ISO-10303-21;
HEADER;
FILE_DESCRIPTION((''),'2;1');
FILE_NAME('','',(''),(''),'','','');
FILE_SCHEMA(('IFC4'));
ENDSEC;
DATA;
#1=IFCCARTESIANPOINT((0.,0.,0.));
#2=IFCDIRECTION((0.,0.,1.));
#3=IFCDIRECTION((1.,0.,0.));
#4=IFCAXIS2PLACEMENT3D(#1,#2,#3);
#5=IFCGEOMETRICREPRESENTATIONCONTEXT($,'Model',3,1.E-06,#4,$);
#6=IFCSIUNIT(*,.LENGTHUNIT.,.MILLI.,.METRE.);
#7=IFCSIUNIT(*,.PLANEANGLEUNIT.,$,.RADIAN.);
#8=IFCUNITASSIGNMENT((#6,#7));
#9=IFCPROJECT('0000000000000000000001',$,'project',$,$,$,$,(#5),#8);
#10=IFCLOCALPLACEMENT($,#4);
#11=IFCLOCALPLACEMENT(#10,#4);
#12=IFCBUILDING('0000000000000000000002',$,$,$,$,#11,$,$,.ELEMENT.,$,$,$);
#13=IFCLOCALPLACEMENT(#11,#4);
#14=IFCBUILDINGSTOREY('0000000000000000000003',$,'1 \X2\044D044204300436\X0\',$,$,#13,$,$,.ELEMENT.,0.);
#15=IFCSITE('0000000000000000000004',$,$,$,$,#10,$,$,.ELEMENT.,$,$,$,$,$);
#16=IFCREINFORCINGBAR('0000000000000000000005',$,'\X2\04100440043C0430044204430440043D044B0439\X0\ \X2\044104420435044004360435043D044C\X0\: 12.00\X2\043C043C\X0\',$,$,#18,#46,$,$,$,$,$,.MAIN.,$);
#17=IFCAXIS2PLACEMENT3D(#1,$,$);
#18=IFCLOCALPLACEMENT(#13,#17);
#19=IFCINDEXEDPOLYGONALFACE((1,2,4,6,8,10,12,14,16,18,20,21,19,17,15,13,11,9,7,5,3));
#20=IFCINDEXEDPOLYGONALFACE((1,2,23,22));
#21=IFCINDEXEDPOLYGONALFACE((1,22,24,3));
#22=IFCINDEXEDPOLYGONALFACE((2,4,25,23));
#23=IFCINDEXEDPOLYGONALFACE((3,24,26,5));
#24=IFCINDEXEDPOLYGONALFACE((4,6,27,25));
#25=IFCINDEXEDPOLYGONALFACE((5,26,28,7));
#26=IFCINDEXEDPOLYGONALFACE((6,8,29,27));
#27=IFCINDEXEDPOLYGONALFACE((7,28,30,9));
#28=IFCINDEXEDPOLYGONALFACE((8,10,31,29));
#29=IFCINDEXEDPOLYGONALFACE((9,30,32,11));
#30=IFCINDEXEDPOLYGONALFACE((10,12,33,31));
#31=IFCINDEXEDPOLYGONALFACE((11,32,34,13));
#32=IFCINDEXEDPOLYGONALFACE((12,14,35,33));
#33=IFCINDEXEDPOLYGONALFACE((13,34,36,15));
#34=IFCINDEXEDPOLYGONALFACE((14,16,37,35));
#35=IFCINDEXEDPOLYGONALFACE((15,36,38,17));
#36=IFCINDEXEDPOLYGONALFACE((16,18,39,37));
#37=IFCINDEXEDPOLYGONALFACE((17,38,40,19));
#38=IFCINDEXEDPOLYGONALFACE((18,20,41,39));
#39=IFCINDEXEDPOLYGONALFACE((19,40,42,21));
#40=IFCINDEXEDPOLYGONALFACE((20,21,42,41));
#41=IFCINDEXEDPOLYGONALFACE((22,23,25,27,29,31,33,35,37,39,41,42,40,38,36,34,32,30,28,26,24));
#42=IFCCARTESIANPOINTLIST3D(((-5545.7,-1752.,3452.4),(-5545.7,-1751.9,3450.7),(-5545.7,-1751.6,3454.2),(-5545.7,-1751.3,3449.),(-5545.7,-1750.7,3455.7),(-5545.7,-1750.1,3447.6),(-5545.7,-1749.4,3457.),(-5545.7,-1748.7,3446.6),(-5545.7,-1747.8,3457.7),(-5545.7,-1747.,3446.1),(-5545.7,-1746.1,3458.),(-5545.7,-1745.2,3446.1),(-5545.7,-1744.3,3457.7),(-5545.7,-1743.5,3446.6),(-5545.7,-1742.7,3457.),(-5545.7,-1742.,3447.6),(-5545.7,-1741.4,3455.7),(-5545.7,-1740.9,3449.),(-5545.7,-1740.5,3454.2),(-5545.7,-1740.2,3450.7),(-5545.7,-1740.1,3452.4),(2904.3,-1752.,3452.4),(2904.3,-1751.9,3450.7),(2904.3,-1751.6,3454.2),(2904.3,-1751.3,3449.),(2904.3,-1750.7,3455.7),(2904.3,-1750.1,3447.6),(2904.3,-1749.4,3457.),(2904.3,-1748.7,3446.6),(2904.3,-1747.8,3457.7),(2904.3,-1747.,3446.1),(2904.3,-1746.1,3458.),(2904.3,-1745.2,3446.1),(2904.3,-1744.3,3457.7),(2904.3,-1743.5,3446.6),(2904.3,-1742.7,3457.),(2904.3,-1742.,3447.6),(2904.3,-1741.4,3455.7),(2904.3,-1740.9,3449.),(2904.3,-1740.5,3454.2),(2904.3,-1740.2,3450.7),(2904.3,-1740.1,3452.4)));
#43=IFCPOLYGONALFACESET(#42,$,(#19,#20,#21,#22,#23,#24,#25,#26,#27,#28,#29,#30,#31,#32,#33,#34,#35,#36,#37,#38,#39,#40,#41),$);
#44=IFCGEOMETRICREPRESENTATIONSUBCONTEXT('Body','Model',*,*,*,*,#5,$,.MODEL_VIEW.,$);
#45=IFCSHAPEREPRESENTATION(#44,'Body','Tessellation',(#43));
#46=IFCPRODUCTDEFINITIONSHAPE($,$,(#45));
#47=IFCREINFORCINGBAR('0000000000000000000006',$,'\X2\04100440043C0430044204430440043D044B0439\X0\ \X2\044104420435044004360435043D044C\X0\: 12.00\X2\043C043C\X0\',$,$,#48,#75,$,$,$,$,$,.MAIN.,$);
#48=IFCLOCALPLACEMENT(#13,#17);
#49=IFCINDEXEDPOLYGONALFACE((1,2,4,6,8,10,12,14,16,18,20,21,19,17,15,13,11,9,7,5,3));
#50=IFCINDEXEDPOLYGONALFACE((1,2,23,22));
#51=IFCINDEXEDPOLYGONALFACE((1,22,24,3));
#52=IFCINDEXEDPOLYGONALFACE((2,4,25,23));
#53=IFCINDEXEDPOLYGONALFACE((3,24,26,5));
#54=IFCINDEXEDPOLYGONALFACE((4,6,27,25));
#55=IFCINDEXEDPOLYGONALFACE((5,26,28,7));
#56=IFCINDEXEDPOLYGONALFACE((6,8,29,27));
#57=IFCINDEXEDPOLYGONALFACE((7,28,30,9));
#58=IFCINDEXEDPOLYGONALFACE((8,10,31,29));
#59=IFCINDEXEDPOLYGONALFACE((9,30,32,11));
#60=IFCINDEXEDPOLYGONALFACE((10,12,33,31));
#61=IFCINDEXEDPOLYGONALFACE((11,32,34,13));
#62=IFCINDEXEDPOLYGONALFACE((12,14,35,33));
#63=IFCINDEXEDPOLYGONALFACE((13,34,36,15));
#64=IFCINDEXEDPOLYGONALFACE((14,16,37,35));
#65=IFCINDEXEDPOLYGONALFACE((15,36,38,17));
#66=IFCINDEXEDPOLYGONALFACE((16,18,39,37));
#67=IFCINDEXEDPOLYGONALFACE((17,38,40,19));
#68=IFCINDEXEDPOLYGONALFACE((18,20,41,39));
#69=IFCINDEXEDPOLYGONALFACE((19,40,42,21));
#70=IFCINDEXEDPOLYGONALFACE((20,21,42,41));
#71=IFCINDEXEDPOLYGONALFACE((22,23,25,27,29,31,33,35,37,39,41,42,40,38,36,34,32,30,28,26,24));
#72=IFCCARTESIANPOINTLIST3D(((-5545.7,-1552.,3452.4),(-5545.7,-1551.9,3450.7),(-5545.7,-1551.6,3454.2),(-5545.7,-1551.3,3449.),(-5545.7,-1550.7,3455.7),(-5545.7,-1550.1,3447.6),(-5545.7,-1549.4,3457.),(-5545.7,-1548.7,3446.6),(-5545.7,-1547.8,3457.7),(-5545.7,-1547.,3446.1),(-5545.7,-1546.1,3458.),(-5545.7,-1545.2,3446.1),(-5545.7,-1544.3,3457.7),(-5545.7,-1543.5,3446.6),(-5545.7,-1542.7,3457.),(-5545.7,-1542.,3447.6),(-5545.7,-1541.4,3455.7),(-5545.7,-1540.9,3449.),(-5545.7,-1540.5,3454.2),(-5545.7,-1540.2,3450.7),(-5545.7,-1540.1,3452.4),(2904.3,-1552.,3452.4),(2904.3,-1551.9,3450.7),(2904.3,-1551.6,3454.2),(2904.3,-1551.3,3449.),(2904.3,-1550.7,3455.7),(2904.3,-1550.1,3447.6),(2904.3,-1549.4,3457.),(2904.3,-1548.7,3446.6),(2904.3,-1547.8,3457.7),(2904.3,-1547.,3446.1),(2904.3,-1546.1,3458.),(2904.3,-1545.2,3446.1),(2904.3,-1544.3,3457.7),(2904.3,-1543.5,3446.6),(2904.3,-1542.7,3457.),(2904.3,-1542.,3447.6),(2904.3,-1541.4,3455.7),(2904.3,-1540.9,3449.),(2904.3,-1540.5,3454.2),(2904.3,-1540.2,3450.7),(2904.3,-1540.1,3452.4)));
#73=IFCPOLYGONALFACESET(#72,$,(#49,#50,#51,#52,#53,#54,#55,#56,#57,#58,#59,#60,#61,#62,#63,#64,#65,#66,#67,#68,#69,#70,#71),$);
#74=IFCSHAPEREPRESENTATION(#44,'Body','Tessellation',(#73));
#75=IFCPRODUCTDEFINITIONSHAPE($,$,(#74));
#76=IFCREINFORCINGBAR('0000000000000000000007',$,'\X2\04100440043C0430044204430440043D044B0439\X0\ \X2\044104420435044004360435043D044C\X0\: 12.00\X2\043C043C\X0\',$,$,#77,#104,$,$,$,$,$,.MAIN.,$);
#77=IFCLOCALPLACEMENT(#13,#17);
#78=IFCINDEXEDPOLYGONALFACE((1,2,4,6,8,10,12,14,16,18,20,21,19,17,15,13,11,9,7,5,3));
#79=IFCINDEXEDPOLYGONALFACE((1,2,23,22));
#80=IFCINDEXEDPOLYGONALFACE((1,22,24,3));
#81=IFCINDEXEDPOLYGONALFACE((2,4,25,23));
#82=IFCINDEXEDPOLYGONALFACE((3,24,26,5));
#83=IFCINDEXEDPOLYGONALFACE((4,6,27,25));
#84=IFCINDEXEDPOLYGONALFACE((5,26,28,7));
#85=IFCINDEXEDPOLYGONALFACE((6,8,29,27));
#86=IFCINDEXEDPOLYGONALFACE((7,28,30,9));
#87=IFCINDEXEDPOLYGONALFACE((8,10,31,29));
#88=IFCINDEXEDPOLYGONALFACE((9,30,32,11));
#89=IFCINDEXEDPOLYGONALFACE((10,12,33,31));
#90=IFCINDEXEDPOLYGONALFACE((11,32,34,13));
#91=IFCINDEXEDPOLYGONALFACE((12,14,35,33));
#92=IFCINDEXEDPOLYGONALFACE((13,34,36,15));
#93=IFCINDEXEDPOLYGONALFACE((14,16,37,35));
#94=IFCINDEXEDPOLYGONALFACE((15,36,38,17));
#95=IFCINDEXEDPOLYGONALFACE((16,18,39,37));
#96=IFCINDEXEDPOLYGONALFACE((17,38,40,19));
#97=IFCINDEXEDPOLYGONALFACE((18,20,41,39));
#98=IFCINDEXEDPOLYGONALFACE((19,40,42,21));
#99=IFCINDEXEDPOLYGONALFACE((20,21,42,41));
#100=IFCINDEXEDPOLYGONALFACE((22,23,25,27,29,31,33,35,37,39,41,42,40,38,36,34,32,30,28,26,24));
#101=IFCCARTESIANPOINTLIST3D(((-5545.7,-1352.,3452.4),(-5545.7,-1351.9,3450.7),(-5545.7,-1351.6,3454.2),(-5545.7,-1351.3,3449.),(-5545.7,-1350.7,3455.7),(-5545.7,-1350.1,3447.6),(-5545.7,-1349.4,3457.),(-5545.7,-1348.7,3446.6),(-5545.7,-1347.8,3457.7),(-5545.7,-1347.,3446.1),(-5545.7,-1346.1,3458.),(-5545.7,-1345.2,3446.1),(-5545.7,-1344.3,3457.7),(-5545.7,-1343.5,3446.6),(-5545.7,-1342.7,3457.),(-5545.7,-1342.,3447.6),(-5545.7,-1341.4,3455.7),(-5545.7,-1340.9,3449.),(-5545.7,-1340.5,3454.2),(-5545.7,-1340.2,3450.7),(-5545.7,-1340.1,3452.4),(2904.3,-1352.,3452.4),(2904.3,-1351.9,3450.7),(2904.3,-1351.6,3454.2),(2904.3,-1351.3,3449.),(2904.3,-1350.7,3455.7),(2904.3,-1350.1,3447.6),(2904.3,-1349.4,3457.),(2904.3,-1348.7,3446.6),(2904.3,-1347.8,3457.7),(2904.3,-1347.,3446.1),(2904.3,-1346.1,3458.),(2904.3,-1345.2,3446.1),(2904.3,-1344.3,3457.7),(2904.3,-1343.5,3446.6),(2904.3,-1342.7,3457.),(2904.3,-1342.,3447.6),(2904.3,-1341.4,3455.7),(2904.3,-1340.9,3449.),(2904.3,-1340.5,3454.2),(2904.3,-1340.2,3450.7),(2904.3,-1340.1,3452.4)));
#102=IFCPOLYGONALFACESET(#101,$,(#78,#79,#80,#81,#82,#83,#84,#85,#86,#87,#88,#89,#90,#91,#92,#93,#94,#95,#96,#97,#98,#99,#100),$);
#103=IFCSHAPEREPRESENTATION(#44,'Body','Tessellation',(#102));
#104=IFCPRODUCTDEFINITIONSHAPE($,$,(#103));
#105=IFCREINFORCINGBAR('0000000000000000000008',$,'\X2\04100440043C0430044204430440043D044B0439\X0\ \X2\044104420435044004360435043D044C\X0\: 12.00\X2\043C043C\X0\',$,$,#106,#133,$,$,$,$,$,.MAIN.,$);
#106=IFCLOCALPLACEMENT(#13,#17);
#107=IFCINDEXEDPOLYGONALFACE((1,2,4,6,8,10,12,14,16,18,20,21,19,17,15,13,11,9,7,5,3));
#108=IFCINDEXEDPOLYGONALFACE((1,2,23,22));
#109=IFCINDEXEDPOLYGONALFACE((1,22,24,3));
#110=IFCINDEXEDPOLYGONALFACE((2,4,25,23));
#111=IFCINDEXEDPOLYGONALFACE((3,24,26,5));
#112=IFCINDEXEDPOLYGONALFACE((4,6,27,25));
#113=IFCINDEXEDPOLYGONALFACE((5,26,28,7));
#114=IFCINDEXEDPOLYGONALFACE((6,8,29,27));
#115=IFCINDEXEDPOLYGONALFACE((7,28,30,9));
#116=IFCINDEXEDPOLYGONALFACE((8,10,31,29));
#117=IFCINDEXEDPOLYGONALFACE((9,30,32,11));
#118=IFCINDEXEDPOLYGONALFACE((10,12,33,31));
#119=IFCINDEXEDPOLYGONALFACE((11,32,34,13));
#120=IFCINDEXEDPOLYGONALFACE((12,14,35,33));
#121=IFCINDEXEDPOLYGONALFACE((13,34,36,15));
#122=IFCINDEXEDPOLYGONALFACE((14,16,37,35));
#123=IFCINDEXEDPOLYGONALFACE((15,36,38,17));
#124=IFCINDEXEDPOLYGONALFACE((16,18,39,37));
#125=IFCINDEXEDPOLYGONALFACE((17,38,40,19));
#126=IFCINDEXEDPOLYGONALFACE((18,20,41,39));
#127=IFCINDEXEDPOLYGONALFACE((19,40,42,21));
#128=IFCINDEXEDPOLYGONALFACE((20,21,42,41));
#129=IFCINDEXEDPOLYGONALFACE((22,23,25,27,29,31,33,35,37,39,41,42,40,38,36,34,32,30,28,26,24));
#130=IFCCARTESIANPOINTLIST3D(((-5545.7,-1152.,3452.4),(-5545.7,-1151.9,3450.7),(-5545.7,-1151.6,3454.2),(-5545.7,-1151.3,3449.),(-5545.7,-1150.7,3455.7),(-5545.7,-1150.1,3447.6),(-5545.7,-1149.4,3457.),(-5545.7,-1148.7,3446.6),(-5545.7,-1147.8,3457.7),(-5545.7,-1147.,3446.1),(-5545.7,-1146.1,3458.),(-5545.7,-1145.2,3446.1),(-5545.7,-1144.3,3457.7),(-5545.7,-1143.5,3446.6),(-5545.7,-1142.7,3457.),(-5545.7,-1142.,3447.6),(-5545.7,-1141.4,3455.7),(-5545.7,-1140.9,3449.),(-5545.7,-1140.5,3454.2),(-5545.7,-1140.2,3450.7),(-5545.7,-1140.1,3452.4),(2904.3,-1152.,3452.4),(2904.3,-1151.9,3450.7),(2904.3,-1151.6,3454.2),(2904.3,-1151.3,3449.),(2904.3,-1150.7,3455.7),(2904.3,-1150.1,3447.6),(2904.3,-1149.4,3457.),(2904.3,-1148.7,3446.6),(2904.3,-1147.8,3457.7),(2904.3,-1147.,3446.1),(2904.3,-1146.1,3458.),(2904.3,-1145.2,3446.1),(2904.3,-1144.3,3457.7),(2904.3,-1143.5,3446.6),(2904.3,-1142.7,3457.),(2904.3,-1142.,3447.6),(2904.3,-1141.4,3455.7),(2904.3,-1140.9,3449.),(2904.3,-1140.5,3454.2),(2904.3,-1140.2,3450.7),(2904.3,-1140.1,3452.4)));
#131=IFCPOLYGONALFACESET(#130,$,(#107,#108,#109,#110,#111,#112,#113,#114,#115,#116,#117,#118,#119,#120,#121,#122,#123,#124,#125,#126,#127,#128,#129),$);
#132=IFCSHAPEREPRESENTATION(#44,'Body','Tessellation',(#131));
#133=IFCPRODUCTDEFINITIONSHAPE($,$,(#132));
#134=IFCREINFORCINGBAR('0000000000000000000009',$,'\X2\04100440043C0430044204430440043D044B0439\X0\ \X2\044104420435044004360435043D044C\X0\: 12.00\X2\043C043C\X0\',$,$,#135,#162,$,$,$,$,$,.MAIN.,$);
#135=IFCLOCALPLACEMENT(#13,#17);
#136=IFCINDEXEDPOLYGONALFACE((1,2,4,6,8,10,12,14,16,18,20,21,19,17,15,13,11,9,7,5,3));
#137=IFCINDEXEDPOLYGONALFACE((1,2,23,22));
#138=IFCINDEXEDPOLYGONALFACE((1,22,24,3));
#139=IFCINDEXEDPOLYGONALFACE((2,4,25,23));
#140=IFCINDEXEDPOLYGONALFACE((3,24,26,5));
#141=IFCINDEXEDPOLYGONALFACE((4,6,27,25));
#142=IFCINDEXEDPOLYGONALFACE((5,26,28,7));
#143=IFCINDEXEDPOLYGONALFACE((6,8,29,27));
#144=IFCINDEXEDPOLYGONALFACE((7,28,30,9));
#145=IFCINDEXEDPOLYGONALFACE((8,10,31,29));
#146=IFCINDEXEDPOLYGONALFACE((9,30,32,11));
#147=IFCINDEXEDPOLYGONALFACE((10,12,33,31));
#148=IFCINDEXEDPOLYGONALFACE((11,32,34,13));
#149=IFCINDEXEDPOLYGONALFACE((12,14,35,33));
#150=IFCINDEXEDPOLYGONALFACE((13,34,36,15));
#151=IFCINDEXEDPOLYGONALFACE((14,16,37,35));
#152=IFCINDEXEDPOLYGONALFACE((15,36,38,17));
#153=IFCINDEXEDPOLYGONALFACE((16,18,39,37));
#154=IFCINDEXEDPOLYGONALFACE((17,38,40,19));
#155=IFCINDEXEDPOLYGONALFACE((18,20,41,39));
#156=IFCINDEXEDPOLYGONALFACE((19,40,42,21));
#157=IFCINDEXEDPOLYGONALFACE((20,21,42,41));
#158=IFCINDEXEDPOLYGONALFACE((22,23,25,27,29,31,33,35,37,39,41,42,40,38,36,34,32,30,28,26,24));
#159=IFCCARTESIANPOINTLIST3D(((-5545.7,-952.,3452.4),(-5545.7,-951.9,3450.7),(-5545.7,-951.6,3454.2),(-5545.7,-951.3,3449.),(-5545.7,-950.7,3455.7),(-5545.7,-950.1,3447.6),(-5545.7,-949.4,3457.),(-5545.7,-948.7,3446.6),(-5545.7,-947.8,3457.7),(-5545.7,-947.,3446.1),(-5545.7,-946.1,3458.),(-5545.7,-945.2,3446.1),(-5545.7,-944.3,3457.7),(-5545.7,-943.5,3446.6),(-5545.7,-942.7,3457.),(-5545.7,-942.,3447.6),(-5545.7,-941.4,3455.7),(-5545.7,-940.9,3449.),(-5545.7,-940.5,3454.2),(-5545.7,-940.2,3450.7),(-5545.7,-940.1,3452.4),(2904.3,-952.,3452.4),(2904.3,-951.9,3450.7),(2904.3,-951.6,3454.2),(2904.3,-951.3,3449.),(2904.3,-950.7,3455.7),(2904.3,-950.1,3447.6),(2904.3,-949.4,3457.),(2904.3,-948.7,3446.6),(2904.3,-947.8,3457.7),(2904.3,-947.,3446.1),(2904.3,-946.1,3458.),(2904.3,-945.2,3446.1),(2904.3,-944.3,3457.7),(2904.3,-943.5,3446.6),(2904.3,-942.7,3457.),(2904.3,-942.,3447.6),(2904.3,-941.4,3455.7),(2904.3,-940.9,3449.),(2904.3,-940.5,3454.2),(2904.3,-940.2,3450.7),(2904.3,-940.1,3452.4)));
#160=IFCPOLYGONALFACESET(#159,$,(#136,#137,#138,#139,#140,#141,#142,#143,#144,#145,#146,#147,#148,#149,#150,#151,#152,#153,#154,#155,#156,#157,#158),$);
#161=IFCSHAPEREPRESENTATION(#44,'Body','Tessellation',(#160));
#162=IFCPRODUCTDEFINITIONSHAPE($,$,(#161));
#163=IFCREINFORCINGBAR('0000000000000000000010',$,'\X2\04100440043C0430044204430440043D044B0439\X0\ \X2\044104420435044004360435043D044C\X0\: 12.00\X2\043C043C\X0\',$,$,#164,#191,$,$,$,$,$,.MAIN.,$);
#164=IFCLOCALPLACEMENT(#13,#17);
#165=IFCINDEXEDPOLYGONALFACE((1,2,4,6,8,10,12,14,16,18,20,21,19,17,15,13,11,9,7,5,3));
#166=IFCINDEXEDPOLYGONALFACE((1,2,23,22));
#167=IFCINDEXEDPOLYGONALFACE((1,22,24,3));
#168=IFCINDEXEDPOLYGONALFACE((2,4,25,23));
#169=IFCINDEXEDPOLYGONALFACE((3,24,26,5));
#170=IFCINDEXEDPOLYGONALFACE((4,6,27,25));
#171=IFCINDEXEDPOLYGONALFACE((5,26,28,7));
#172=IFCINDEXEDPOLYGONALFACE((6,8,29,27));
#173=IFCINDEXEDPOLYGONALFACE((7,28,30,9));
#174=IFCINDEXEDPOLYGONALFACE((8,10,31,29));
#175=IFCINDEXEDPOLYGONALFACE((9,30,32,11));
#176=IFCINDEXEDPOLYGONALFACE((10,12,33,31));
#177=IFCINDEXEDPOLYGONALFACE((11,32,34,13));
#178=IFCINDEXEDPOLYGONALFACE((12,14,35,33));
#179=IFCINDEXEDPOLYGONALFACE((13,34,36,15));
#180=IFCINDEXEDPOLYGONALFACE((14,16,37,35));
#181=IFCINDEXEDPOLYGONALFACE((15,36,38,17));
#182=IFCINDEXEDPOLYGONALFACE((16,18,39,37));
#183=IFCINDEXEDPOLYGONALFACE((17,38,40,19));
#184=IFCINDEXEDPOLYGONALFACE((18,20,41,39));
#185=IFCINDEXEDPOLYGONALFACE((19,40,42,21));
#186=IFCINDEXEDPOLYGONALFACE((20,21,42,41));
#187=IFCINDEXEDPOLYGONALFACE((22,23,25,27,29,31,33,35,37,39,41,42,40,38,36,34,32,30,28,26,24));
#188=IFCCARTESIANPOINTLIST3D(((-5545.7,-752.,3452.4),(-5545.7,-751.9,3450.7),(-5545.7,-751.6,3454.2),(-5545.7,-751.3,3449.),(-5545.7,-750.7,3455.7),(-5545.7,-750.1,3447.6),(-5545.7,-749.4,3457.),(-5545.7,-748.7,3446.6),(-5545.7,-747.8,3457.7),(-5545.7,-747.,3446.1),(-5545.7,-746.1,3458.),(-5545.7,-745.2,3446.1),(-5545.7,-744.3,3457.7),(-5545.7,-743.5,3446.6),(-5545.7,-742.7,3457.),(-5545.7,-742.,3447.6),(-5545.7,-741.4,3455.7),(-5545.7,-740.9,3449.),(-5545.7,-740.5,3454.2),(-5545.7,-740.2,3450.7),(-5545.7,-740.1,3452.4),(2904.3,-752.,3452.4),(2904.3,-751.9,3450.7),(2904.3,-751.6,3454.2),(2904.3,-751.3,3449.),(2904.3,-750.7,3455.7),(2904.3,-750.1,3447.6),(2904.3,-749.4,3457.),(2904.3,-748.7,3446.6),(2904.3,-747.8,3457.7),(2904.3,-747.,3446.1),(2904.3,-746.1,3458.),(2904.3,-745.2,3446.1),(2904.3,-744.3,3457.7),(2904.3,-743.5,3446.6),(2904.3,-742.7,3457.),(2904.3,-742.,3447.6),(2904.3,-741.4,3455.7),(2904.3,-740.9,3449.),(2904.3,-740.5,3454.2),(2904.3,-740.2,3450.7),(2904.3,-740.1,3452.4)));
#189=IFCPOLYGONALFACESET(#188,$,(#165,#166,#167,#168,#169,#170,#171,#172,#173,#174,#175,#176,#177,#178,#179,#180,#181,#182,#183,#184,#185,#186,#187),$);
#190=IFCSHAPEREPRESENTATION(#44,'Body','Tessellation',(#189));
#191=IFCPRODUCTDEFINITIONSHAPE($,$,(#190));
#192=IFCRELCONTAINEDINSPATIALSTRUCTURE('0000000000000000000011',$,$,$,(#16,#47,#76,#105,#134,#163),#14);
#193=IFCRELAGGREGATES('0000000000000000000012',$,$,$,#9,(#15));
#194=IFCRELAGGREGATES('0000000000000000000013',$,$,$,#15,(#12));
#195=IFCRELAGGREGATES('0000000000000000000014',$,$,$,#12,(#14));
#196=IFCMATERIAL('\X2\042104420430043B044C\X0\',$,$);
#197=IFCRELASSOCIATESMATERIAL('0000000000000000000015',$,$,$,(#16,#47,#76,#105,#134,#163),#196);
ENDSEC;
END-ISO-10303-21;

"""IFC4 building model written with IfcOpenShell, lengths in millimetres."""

from ifc_helpers import new_model, entity, si_unit, origin_with_axes, place, context, subcontext, project, spatial, source, transform, mapped, material, element, save


model = new_model("IFC4")

# Units and contexts
model_context = context("Model", 3, precision=1e-06, world=origin_with_axes())
body_context = subcontext(model_context, "Body", "Model", "MODEL_VIEW")
ifc_project = project(units=[si_unit("LENGTHUNIT", "METRE", prefix="MILLI"), si_unit("PLANEANGLEUNIT", "RADIAN")], contexts=[model_context])

# Site, building, storey
site_placement = place(None, origin_with_axes())
site = spatial("IfcSite", under=ifc_project, at=site_placement, CompositionType="ELEMENT")
building_placement = place(site_placement, origin_with_axes())
building = spatial("IfcBuilding", under=site, at=building_placement, CompositionType="ELEMENT")
storey_placement = place(building_placement, origin_with_axes())
storey = spatial("IfcBuildingStorey", under=building, at=storey_placement, Name="1 этаж", CompositionType="ELEMENT", Elevation=0.0)

# Reinforcing bars
ifc_material_1 = material(Name="Сталь")
shared_shape_1 = source(origin_with_axes(), body_context, "Body", "AdvancedSweptSolid", [
    entity("IfcSweptDiskSolid", entity("IfcIndexedPolyCurve", entity("IfcCartesianPointList3D", [[0.0, 0.0, 0.0], [8450.0, 0.0, 0.0]]), [entity("IfcLineIndex", [1, 2])]), 6.0),
])
reinforcing_bar_1_placement = place(storey_placement, origin_with_axes())
element("IfcReinforcingBar", 1, at=reinforcing_bar_1_placement, inside=storey, material=ifc_material_1, Name="Арматурный стержень: 12.00мм", PredefinedType="MAIN", context=body_context, shape_type="MappedRepresentation", body=[
    mapped(shared_shape_1, transform((-5545.7, -1746.1, 3452.0), x_axis=(1.0, 0.0, 0.0), y_axis=(0.0, 1.0, 0.0), z_axis=(0.0, 0.0, 1.0), scale=1.0)),
])
reinforcing_bar_2_placement = place(storey_placement, origin_with_axes())
element("IfcReinforcingBar", 2, at=reinforcing_bar_2_placement, inside=storey, material=ifc_material_1, Name="Арматурный стержень: 12.00мм", PredefinedType="MAIN", context=body_context, shape_type="MappedRepresentation", body=[
    mapped(shared_shape_1, transform((-5545.7, -1546.1, 3452.0), x_axis=(1.0, 0.0, 0.0), y_axis=(0.0, 1.0, 0.0), z_axis=(0.0, 0.0, 1.0), scale=1.0)),
])
reinforcing_bar_3_placement = place(storey_placement, origin_with_axes())
element("IfcReinforcingBar", 3, at=reinforcing_bar_3_placement, inside=storey, material=ifc_material_1, Name="Арматурный стержень: 12.00мм", PredefinedType="MAIN", context=body_context, shape_type="MappedRepresentation", body=[
    mapped(shared_shape_1, transform((-5545.7, -1346.1, 3452.0), x_axis=(1.0, 0.0, 0.0), y_axis=(0.0, 1.0, 0.0), z_axis=(0.0, 0.0, 1.0), scale=1.0)),
])
reinforcing_bar_4_placement = place(storey_placement, origin_with_axes())
element("IfcReinforcingBar", 4, at=reinforcing_bar_4_placement, inside=storey, material=ifc_material_1, Name="Арматурный стержень: 12.00мм", PredefinedType="MAIN", context=body_context, shape_type="MappedRepresentation", body=[
    mapped(shared_shape_1, transform((-5545.7, -1146.1, 3452.0), x_axis=(1.0, 0.0, 0.0), y_axis=(0.0, 1.0, 0.0), z_axis=(0.0, 0.0, 1.0), scale=1.0)),
])
reinforcing_bar_5_placement = place(storey_placement, origin_with_axes())
element("IfcReinforcingBar", 5, at=reinforcing_bar_5_placement, inside=storey, material=ifc_material_1, Name="Арматурный стержень: 12.00мм", PredefinedType="MAIN", context=body_context, shape_type="MappedRepresentation", body=[
    mapped(shared_shape_1, transform((-5545.7, -946.1, 3452.0), x_axis=(1.0, 0.0, 0.0), y_axis=(0.0, 1.0, 0.0), z_axis=(0.0, 0.0, 1.0), scale=1.0)),
])
reinforcing_bar_6_placement = place(storey_placement, origin_with_axes())
element("IfcReinforcingBar", 6, at=reinforcing_bar_6_placement, inside=storey, material=ifc_material_1, Name="Арматурный стержень: 12.00мм", PredefinedType="MAIN", context=body_context, shape_type="MappedRepresentation", body=[
    mapped(shared_shape_1, transform((-5545.7, -746.1, 3452.0), x_axis=(1.0, 0.0, 0.0), y_axis=(0.0, 1.0, 0.0), z_axis=(0.0, 0.0, 1.0), scale=1.0)),
])

save(model, "model.ifc")
